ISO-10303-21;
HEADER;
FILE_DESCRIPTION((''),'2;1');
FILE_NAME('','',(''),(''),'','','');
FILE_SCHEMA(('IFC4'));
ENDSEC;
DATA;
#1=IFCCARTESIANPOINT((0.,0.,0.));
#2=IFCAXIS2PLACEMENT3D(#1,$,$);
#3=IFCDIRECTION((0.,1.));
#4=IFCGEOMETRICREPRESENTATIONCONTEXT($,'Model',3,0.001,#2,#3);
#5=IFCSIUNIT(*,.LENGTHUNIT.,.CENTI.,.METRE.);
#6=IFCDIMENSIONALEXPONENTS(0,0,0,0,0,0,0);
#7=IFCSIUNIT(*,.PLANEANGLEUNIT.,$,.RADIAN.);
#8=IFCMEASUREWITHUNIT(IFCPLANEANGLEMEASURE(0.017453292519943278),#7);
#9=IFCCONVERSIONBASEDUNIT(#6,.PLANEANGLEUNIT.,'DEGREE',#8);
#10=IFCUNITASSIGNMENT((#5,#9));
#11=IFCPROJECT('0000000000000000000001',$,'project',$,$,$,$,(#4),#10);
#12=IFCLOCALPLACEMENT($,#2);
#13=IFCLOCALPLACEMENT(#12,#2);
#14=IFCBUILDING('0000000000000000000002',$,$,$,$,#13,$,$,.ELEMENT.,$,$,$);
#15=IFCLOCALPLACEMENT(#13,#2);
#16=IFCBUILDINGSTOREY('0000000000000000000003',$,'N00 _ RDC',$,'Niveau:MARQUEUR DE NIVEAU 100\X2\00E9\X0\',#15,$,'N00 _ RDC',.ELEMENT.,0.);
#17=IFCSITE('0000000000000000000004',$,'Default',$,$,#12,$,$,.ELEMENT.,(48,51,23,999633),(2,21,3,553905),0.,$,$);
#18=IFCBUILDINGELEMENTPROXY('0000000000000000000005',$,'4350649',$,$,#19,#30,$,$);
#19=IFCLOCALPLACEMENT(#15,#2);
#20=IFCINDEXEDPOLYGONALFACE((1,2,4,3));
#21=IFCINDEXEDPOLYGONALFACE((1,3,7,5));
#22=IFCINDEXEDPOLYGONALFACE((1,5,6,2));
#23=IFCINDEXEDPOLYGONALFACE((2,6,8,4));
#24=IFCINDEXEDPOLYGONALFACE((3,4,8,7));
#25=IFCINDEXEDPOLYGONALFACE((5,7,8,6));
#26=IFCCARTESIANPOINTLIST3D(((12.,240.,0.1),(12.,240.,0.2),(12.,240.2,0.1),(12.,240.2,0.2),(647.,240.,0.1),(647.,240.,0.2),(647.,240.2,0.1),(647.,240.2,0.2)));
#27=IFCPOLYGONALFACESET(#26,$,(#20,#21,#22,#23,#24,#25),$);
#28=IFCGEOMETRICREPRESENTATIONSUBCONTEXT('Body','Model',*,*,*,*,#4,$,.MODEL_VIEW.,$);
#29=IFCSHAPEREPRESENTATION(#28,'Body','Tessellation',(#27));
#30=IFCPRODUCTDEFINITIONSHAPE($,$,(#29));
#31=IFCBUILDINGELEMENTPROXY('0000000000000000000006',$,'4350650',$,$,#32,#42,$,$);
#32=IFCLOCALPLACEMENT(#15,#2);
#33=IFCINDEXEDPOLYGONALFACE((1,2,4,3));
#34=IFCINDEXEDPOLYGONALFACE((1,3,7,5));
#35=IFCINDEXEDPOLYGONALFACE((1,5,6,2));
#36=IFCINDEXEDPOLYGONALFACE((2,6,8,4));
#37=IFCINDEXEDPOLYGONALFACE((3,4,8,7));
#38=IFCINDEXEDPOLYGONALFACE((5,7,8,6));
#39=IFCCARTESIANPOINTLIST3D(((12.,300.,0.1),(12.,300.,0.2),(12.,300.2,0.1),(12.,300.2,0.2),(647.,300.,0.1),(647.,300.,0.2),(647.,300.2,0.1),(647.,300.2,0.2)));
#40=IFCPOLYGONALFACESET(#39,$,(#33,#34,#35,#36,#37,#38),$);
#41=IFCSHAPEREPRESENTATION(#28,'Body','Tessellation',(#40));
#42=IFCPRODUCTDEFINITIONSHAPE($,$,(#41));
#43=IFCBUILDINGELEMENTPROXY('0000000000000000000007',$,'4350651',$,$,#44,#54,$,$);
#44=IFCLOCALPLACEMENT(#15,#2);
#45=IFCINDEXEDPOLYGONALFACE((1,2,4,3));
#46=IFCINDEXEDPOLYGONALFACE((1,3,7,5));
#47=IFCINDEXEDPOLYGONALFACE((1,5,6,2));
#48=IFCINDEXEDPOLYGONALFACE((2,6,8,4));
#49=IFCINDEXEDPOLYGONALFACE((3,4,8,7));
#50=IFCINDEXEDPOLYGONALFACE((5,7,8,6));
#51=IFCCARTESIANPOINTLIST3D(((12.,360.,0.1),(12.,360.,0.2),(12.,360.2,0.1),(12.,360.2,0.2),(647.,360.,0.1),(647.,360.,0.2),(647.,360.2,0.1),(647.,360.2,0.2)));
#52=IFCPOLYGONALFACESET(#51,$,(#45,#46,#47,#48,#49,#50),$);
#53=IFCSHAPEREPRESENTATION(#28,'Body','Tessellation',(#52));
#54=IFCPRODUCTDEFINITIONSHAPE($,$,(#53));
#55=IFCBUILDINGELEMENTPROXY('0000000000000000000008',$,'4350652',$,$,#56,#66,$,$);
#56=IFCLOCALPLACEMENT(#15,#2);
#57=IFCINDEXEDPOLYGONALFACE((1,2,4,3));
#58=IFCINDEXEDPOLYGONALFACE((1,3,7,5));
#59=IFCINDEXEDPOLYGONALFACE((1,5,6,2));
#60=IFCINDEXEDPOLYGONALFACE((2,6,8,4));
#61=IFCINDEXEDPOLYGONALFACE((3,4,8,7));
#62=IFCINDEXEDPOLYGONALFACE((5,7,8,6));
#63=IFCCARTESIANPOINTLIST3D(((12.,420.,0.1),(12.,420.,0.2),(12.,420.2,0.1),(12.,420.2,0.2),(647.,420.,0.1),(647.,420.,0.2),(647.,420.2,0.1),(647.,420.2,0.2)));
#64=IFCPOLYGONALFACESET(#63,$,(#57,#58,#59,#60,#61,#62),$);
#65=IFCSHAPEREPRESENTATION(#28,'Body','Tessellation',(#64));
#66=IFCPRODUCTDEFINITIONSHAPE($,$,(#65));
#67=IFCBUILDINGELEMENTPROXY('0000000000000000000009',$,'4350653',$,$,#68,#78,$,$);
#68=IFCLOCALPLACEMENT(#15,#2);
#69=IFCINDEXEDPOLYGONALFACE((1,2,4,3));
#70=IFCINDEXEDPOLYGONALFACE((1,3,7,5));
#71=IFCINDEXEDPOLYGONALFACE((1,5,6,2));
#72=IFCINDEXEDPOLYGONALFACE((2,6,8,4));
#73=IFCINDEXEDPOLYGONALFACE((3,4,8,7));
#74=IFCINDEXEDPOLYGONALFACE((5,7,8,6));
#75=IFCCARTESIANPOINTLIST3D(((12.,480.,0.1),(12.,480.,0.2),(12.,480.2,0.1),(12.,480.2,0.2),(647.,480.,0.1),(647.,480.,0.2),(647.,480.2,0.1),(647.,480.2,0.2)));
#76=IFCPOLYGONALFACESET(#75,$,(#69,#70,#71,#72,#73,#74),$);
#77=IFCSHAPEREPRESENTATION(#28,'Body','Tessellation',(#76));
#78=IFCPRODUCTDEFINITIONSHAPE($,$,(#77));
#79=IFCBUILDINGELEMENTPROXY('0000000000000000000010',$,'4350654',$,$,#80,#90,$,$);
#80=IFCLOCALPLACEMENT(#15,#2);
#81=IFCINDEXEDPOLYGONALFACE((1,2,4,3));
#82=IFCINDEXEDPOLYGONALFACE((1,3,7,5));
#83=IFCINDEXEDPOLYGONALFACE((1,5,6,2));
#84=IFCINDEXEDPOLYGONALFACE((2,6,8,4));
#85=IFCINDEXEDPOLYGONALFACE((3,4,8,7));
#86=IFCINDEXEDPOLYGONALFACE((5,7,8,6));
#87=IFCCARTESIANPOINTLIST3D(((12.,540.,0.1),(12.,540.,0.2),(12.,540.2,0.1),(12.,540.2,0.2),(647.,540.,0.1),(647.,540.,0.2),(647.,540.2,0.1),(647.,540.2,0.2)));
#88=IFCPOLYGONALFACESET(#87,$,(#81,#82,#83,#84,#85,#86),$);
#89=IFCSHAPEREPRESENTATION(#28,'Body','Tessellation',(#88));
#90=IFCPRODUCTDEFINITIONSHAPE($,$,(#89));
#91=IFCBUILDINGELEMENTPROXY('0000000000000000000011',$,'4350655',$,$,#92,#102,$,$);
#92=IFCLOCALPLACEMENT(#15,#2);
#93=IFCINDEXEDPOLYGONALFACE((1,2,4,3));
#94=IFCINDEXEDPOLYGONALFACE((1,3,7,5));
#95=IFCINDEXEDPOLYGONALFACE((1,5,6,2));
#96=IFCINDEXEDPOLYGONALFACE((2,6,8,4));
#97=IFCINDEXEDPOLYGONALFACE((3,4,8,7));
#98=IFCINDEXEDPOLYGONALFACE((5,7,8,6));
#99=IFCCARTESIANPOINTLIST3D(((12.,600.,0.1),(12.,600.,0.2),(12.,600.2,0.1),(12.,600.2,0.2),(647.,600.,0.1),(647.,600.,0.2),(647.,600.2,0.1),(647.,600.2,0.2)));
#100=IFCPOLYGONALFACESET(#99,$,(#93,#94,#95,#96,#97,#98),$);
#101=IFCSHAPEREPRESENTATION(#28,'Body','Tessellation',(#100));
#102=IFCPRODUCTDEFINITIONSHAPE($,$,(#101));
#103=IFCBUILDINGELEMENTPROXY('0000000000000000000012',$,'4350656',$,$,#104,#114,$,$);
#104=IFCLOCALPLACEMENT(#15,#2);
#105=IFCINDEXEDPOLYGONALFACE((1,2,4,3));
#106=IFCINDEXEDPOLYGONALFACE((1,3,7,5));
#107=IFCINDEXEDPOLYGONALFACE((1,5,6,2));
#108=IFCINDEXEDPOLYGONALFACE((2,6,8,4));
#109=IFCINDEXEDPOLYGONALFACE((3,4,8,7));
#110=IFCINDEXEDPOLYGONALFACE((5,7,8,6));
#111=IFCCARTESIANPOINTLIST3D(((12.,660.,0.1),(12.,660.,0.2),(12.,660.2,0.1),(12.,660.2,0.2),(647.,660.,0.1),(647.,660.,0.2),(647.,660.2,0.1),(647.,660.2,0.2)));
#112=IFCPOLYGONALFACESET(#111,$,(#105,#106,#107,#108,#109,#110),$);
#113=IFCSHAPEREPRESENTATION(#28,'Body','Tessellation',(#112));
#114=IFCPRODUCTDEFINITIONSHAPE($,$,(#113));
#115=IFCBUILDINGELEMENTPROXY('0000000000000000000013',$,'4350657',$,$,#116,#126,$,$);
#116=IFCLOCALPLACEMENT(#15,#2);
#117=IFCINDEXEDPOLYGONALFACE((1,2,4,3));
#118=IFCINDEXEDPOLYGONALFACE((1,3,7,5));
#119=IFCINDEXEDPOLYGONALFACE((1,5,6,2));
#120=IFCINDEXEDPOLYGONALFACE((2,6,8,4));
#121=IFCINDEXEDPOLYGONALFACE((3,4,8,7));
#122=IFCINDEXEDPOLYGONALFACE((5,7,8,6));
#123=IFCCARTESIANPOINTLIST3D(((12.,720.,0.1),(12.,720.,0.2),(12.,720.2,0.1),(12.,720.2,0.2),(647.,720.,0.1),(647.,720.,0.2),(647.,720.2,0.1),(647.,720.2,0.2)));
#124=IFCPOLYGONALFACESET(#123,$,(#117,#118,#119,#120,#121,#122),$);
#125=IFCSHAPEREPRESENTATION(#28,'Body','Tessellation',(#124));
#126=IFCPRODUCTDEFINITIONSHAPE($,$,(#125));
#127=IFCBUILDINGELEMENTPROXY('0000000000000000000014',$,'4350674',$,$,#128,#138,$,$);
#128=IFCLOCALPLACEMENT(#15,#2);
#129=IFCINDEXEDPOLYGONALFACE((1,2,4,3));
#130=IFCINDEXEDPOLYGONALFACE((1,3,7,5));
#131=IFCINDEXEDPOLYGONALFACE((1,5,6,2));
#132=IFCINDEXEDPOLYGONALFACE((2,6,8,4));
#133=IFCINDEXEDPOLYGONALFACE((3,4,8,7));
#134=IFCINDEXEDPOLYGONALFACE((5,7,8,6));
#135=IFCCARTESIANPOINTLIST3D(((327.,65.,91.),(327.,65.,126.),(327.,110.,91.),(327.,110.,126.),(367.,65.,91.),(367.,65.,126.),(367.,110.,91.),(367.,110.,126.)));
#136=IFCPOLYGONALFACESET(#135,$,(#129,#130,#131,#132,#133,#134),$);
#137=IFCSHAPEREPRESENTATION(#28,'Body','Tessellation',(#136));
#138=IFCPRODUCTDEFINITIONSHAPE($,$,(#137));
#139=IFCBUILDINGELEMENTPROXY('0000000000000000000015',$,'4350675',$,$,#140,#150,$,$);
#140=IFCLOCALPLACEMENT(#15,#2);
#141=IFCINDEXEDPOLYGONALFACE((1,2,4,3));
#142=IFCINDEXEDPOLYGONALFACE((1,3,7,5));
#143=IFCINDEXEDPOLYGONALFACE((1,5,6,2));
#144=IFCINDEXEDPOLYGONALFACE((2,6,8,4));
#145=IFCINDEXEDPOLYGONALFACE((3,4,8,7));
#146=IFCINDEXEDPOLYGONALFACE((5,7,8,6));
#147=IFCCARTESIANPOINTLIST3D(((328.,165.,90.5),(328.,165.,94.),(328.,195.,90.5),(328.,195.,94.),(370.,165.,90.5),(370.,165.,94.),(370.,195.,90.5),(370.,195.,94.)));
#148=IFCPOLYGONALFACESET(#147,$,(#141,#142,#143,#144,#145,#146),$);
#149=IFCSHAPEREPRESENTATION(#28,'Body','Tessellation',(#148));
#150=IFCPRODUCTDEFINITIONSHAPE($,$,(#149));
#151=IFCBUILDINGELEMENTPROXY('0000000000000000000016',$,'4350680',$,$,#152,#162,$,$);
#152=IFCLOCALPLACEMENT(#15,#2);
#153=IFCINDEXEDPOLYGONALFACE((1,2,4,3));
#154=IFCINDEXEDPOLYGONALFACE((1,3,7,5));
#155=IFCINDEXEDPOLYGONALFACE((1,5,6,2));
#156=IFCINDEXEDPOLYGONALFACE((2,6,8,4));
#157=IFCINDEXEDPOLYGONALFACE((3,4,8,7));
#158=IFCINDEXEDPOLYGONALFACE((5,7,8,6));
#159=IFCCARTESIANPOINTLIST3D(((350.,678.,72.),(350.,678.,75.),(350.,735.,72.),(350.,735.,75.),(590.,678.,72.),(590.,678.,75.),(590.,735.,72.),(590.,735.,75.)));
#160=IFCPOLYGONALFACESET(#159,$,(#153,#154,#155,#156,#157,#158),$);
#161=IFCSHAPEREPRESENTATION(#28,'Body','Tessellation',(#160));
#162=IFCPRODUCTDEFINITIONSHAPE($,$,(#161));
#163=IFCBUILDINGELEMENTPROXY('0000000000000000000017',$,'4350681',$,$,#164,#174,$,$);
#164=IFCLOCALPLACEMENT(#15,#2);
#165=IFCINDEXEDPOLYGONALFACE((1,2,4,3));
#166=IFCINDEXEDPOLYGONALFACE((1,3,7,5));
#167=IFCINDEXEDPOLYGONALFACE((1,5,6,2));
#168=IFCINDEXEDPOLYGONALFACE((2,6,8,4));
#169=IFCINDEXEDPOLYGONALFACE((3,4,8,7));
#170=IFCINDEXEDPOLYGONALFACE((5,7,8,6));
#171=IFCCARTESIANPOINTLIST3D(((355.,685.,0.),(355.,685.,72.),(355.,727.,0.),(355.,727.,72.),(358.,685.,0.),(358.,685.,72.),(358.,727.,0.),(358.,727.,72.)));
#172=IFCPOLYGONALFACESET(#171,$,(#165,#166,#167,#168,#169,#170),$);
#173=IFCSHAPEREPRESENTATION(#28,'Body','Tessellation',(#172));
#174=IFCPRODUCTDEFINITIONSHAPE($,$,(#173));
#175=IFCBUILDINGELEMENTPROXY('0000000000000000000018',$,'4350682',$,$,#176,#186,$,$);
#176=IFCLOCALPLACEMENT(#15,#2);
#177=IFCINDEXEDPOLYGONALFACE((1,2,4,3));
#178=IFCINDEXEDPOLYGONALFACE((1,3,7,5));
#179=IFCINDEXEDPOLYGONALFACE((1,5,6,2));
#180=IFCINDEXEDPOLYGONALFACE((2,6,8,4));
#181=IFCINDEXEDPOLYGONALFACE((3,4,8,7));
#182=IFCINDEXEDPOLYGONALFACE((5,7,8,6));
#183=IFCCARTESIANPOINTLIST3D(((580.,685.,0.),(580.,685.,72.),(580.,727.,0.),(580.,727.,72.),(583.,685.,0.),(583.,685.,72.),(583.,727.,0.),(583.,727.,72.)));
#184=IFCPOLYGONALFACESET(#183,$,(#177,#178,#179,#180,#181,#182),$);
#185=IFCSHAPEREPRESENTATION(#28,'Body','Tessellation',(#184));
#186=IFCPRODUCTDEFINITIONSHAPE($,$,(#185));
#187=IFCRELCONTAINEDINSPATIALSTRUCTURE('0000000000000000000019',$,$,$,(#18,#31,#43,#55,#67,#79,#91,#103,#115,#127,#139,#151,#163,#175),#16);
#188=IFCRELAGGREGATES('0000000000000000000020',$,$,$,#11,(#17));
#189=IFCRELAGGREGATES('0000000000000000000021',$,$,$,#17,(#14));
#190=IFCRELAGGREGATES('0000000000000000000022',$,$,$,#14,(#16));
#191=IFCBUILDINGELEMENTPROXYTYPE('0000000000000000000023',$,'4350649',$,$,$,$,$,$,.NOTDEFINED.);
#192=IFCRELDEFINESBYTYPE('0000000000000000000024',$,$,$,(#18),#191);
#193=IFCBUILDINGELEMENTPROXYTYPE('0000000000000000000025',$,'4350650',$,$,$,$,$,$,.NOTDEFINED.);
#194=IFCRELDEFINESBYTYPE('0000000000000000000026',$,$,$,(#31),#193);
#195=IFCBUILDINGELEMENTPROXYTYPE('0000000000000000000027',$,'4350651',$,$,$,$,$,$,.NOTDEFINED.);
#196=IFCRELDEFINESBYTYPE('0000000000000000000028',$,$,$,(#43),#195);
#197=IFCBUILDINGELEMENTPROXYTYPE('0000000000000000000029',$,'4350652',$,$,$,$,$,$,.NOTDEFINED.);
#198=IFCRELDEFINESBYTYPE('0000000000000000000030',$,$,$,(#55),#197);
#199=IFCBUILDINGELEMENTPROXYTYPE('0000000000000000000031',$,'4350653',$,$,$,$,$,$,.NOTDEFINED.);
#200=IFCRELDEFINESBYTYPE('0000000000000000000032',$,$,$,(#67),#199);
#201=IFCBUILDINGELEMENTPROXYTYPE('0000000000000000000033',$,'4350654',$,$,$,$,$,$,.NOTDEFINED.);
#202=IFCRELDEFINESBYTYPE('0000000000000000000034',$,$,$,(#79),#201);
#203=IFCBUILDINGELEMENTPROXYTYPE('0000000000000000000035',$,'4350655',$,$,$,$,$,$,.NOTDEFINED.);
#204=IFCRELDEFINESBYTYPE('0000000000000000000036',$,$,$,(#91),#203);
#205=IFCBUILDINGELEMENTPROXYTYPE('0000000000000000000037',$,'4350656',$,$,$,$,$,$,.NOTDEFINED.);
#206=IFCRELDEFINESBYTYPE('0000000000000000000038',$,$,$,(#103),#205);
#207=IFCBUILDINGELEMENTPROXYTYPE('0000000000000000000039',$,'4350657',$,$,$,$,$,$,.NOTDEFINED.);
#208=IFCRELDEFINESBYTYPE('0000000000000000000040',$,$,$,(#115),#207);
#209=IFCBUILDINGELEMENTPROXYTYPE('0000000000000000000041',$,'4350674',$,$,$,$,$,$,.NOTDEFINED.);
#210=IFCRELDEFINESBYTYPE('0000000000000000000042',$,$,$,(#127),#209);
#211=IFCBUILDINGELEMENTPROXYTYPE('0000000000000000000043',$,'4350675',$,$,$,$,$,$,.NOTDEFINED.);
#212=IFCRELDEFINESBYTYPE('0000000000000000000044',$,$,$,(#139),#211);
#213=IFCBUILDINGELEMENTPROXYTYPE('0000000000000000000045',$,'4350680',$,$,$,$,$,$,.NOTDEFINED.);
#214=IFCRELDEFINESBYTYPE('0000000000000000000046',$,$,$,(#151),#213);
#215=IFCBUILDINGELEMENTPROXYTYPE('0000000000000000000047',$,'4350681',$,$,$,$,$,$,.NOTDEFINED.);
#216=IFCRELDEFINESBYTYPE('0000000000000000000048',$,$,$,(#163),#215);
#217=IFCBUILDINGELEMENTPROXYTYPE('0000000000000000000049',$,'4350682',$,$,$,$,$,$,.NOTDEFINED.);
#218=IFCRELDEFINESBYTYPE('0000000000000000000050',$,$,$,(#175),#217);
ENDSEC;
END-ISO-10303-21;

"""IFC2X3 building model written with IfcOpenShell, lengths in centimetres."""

from ifc_helpers import new_model, entity, si_unit, converted_unit, direction, frame, frame_2d, origin, origin_2d_with_axis, place, context, subcontext, project, spatial, rectangle, extrude, type_object, element, save


model = new_model("IFC2X3")

# Units and contexts
model_context = context("Model", 3, precision=0.001, world=origin(), true_north=direction((0.0, 1.0)))
body_context = subcontext(model_context, "Body", "Model", "MODEL_VIEW")
ifc_project = project(units=[si_unit("LENGTHUNIT", "METRE", prefix="CENTI"), converted_unit("PLANEANGLEUNIT", "DEGREE", entity("IfcPlaneAngleMeasure", 0.017453292519943278), si_unit("PLANEANGLEUNIT", "RADIAN"), dimensions=[0, 0, 0, 0, 0, 0, 0])], contexts=[model_context])

# Site, building, storey
site_placement = place(None, origin())
site = spatial("IfcSite", under=ifc_project, at=site_placement, Name="Default", CompositionType="ELEMENT", RefLatitude=(48, 51, 23, 999633), RefLongitude=(2, 21, 3, 553905), RefElevation=0.0)
building_placement = place(site_placement, origin())
building = spatial("IfcBuilding", under=site, at=building_placement, CompositionType="ELEMENT")
storey_placement = place(building_placement, origin())
storey = spatial("IfcBuildingStorey", under=building, at=storey_placement, Name="N00 _ RDC", ObjectType="Niveau:MARQUEUR DE NIVEAU 100é", LongName="N00 _ RDC", CompositionType="ELEMENT", Elevation=0.0)

# Building element proxies
building_element_proxy_type_1 = type_object("IfcBuildingElementProxyType", Name="4350649", PredefinedType="NOTDEFINED")
proxy_1_placement = place(storey_placement, origin())
element("IfcBuildingElementProxy", 1, at=proxy_1_placement, inside=storey, type_object=building_element_proxy_type_1, Name="4350649", context=body_context, shape_type="SweptSolid", body=[
    extrude(rectangle(XDim=635.0, YDim=0.2, at=frame_2d((0.0, 0.0), x_axis=(1.0, 0.0))), frame((329.5, 240.1, 0.1)), (0.0, 0.0, 1.0), 0.1),
])
building_element_proxy_type_2 = type_object("IfcBuildingElementProxyType", Name="4350650", PredefinedType="NOTDEFINED")
proxy_2_placement = place(storey_placement, origin())
element("IfcBuildingElementProxy", 2, at=proxy_2_placement, inside=storey, type_object=building_element_proxy_type_2, Name="4350650", context=body_context, shape_type="SweptSolid", body=[
    extrude(rectangle(XDim=635.0, YDim=0.2, at=frame_2d((0.0, 0.0), x_axis=(1.0, 0.0))), frame((329.5, 300.1, 0.1)), (0.0, 0.0, 1.0), 0.1),
])
building_element_proxy_type_3 = type_object("IfcBuildingElementProxyType", Name="4350651", PredefinedType="NOTDEFINED")
proxy_3_placement = place(storey_placement, origin())
element("IfcBuildingElementProxy", 3, at=proxy_3_placement, inside=storey, type_object=building_element_proxy_type_3, Name="4350651", context=body_context, shape_type="SweptSolid", body=[
    extrude(rectangle(XDim=635.0, YDim=0.2, at=frame_2d((0.0, 0.0), x_axis=(1.0, 0.0))), frame((329.5, 360.1, 0.1)), (0.0, 0.0, 1.0), 0.1),
])
building_element_proxy_type_4 = type_object("IfcBuildingElementProxyType", Name="4350652", PredefinedType="NOTDEFINED")
proxy_4_placement = place(storey_placement, origin())
element("IfcBuildingElementProxy", 4, at=proxy_4_placement, inside=storey, type_object=building_element_proxy_type_4, Name="4350652", context=body_context, shape_type="SweptSolid", body=[
    extrude(rectangle(XDim=635.0, YDim=0.2, at=frame_2d((0.0, 0.0), x_axis=(1.0, 0.0))), frame((329.5, 420.1, 0.1)), (0.0, 0.0, 1.0), 0.1),
])
building_element_proxy_type_5 = type_object("IfcBuildingElementProxyType", Name="4350653", PredefinedType="NOTDEFINED")
proxy_5_placement = place(storey_placement, origin())
element("IfcBuildingElementProxy", 5, at=proxy_5_placement, inside=storey, type_object=building_element_proxy_type_5, Name="4350653", context=body_context, shape_type="SweptSolid", body=[
    extrude(rectangle(XDim=635.0, YDim=0.2, at=frame_2d((0.0, 0.0), x_axis=(1.0, 0.0))), frame((329.5, 480.1, 0.1)), (0.0, 0.0, 1.0), 0.1),
])
building_element_proxy_type_6 = type_object("IfcBuildingElementProxyType", Name="4350654", PredefinedType="NOTDEFINED")
proxy_6_placement = place(storey_placement, origin())
element("IfcBuildingElementProxy", 6, at=proxy_6_placement, inside=storey, type_object=building_element_proxy_type_6, Name="4350654", context=body_context, shape_type="SweptSolid", body=[
    extrude(rectangle(XDim=635.0, YDim=0.2, at=frame_2d((0.0, 0.0), x_axis=(1.0, 0.0))), frame((329.5, 540.1, 0.1)), (0.0, 0.0, 1.0), 0.1),
])
building_element_proxy_type_7 = type_object("IfcBuildingElementProxyType", Name="4350655", PredefinedType="NOTDEFINED")
proxy_7_placement = place(storey_placement, origin())
element("IfcBuildingElementProxy", 7, at=proxy_7_placement, inside=storey, type_object=building_element_proxy_type_7, Name="4350655", context=body_context, shape_type="SweptSolid", body=[
    extrude(rectangle(XDim=635.0, YDim=0.2, at=frame_2d((0.0, 0.0), x_axis=(1.0, 0.0))), frame((329.5, 600.1, 0.1)), (0.0, 0.0, 1.0), 0.1),
])
building_element_proxy_type_8 = type_object("IfcBuildingElementProxyType", Name="4350656", PredefinedType="NOTDEFINED")
proxy_8_placement = place(storey_placement, origin())
element("IfcBuildingElementProxy", 8, at=proxy_8_placement, inside=storey, type_object=building_element_proxy_type_8, Name="4350656", context=body_context, shape_type="SweptSolid", body=[
    extrude(rectangle(XDim=635.0, YDim=0.2, at=frame_2d((0.0, 0.0), x_axis=(1.0, 0.0))), frame((329.5, 660.1, 0.1)), (0.0, 0.0, 1.0), 0.1),
])
building_element_proxy_type_9 = type_object("IfcBuildingElementProxyType", Name="4350657", PredefinedType="NOTDEFINED")
proxy_9_placement = place(storey_placement, origin())
element("IfcBuildingElementProxy", 9, at=proxy_9_placement, inside=storey, type_object=building_element_proxy_type_9, Name="4350657", context=body_context, shape_type="SweptSolid", body=[
    extrude(rectangle(XDim=635.0, YDim=0.2, at=frame_2d((0.0, 0.0), x_axis=(1.0, 0.0))), frame((329.5, 720.1, 0.1)), (0.0, 0.0, 1.0), 0.1),
])
building_element_proxy_type_10 = type_object("IfcBuildingElementProxyType", Name="4350674", PredefinedType="NOTDEFINED")
proxy_10_placement = place(storey_placement, origin())
element("IfcBuildingElementProxy", 10, at=proxy_10_placement, inside=storey, type_object=building_element_proxy_type_10, Name="4350674", context=body_context, shape_type="SweptSolid", body=[
    extrude(rectangle(XDim=40.0, YDim=45.0, at=origin_2d_with_axis()), frame((347.0, 87.5, 91.0)), (0.0, 0.0, 1.0), 35.0),
])
building_element_proxy_type_11 = type_object("IfcBuildingElementProxyType", Name="4350675", PredefinedType="NOTDEFINED")
proxy_11_placement = place(storey_placement, origin())
element("IfcBuildingElementProxy", 11, at=proxy_11_placement, inside=storey, type_object=building_element_proxy_type_11, Name="4350675", context=body_context, shape_type="SweptSolid", body=[
    extrude(rectangle(XDim=42.0, YDim=30.0, at=origin_2d_with_axis()), frame((349.0, 180.0, 90.5)), (0.0, 0.0, 1.0), 3.5),
])
building_element_proxy_type_12 = type_object("IfcBuildingElementProxyType", Name="4350680", PredefinedType="NOTDEFINED")
proxy_12_placement = place(storey_placement, origin())
element("IfcBuildingElementProxy", 12, at=proxy_12_placement, inside=storey, type_object=building_element_proxy_type_12, Name="4350680", context=body_context, shape_type="SweptSolid", body=[
    extrude(rectangle(XDim=240.0, YDim=57.0, at=frame_2d((0.0, 0.0), x_axis=(1.0, 0.0))), frame((470.0, 706.5, 72.0)), (0.0, 0.0, 1.0), 3.0),
])
building_element_proxy_type_13 = type_object("IfcBuildingElementProxyType", Name="4350681", PredefinedType="NOTDEFINED")
proxy_13_placement = place(storey_placement, origin())
element("IfcBuildingElementProxy", 13, at=proxy_13_placement, inside=storey, type_object=building_element_proxy_type_13, Name="4350681", context=body_context, shape_type="SweptSolid", body=[
    extrude(rectangle(XDim=3.0, YDim=42.0, at=origin_2d_with_axis()), frame((356.5, 706.0, 0.0)), (0.0, 0.0, 1.0), 72.0),
])
building_element_proxy_type_14 = type_object("IfcBuildingElementProxyType", Name="4350682", PredefinedType="NOTDEFINED")
proxy_14_placement = place(storey_placement, origin())
element("IfcBuildingElementProxy", 14, at=proxy_14_placement, inside=storey, type_object=building_element_proxy_type_14, Name="4350682", context=body_context, shape_type="SweptSolid", body=[
    extrude(rectangle(XDim=3.0, YDim=42.0, at=frame_2d((0.0, 0.0), x_axis=(1.0, 0.0))), frame((581.5, 706.0, 0.0)), (0.0, 0.0, 1.0), 72.0),
])

save(model, "model.ifc")
